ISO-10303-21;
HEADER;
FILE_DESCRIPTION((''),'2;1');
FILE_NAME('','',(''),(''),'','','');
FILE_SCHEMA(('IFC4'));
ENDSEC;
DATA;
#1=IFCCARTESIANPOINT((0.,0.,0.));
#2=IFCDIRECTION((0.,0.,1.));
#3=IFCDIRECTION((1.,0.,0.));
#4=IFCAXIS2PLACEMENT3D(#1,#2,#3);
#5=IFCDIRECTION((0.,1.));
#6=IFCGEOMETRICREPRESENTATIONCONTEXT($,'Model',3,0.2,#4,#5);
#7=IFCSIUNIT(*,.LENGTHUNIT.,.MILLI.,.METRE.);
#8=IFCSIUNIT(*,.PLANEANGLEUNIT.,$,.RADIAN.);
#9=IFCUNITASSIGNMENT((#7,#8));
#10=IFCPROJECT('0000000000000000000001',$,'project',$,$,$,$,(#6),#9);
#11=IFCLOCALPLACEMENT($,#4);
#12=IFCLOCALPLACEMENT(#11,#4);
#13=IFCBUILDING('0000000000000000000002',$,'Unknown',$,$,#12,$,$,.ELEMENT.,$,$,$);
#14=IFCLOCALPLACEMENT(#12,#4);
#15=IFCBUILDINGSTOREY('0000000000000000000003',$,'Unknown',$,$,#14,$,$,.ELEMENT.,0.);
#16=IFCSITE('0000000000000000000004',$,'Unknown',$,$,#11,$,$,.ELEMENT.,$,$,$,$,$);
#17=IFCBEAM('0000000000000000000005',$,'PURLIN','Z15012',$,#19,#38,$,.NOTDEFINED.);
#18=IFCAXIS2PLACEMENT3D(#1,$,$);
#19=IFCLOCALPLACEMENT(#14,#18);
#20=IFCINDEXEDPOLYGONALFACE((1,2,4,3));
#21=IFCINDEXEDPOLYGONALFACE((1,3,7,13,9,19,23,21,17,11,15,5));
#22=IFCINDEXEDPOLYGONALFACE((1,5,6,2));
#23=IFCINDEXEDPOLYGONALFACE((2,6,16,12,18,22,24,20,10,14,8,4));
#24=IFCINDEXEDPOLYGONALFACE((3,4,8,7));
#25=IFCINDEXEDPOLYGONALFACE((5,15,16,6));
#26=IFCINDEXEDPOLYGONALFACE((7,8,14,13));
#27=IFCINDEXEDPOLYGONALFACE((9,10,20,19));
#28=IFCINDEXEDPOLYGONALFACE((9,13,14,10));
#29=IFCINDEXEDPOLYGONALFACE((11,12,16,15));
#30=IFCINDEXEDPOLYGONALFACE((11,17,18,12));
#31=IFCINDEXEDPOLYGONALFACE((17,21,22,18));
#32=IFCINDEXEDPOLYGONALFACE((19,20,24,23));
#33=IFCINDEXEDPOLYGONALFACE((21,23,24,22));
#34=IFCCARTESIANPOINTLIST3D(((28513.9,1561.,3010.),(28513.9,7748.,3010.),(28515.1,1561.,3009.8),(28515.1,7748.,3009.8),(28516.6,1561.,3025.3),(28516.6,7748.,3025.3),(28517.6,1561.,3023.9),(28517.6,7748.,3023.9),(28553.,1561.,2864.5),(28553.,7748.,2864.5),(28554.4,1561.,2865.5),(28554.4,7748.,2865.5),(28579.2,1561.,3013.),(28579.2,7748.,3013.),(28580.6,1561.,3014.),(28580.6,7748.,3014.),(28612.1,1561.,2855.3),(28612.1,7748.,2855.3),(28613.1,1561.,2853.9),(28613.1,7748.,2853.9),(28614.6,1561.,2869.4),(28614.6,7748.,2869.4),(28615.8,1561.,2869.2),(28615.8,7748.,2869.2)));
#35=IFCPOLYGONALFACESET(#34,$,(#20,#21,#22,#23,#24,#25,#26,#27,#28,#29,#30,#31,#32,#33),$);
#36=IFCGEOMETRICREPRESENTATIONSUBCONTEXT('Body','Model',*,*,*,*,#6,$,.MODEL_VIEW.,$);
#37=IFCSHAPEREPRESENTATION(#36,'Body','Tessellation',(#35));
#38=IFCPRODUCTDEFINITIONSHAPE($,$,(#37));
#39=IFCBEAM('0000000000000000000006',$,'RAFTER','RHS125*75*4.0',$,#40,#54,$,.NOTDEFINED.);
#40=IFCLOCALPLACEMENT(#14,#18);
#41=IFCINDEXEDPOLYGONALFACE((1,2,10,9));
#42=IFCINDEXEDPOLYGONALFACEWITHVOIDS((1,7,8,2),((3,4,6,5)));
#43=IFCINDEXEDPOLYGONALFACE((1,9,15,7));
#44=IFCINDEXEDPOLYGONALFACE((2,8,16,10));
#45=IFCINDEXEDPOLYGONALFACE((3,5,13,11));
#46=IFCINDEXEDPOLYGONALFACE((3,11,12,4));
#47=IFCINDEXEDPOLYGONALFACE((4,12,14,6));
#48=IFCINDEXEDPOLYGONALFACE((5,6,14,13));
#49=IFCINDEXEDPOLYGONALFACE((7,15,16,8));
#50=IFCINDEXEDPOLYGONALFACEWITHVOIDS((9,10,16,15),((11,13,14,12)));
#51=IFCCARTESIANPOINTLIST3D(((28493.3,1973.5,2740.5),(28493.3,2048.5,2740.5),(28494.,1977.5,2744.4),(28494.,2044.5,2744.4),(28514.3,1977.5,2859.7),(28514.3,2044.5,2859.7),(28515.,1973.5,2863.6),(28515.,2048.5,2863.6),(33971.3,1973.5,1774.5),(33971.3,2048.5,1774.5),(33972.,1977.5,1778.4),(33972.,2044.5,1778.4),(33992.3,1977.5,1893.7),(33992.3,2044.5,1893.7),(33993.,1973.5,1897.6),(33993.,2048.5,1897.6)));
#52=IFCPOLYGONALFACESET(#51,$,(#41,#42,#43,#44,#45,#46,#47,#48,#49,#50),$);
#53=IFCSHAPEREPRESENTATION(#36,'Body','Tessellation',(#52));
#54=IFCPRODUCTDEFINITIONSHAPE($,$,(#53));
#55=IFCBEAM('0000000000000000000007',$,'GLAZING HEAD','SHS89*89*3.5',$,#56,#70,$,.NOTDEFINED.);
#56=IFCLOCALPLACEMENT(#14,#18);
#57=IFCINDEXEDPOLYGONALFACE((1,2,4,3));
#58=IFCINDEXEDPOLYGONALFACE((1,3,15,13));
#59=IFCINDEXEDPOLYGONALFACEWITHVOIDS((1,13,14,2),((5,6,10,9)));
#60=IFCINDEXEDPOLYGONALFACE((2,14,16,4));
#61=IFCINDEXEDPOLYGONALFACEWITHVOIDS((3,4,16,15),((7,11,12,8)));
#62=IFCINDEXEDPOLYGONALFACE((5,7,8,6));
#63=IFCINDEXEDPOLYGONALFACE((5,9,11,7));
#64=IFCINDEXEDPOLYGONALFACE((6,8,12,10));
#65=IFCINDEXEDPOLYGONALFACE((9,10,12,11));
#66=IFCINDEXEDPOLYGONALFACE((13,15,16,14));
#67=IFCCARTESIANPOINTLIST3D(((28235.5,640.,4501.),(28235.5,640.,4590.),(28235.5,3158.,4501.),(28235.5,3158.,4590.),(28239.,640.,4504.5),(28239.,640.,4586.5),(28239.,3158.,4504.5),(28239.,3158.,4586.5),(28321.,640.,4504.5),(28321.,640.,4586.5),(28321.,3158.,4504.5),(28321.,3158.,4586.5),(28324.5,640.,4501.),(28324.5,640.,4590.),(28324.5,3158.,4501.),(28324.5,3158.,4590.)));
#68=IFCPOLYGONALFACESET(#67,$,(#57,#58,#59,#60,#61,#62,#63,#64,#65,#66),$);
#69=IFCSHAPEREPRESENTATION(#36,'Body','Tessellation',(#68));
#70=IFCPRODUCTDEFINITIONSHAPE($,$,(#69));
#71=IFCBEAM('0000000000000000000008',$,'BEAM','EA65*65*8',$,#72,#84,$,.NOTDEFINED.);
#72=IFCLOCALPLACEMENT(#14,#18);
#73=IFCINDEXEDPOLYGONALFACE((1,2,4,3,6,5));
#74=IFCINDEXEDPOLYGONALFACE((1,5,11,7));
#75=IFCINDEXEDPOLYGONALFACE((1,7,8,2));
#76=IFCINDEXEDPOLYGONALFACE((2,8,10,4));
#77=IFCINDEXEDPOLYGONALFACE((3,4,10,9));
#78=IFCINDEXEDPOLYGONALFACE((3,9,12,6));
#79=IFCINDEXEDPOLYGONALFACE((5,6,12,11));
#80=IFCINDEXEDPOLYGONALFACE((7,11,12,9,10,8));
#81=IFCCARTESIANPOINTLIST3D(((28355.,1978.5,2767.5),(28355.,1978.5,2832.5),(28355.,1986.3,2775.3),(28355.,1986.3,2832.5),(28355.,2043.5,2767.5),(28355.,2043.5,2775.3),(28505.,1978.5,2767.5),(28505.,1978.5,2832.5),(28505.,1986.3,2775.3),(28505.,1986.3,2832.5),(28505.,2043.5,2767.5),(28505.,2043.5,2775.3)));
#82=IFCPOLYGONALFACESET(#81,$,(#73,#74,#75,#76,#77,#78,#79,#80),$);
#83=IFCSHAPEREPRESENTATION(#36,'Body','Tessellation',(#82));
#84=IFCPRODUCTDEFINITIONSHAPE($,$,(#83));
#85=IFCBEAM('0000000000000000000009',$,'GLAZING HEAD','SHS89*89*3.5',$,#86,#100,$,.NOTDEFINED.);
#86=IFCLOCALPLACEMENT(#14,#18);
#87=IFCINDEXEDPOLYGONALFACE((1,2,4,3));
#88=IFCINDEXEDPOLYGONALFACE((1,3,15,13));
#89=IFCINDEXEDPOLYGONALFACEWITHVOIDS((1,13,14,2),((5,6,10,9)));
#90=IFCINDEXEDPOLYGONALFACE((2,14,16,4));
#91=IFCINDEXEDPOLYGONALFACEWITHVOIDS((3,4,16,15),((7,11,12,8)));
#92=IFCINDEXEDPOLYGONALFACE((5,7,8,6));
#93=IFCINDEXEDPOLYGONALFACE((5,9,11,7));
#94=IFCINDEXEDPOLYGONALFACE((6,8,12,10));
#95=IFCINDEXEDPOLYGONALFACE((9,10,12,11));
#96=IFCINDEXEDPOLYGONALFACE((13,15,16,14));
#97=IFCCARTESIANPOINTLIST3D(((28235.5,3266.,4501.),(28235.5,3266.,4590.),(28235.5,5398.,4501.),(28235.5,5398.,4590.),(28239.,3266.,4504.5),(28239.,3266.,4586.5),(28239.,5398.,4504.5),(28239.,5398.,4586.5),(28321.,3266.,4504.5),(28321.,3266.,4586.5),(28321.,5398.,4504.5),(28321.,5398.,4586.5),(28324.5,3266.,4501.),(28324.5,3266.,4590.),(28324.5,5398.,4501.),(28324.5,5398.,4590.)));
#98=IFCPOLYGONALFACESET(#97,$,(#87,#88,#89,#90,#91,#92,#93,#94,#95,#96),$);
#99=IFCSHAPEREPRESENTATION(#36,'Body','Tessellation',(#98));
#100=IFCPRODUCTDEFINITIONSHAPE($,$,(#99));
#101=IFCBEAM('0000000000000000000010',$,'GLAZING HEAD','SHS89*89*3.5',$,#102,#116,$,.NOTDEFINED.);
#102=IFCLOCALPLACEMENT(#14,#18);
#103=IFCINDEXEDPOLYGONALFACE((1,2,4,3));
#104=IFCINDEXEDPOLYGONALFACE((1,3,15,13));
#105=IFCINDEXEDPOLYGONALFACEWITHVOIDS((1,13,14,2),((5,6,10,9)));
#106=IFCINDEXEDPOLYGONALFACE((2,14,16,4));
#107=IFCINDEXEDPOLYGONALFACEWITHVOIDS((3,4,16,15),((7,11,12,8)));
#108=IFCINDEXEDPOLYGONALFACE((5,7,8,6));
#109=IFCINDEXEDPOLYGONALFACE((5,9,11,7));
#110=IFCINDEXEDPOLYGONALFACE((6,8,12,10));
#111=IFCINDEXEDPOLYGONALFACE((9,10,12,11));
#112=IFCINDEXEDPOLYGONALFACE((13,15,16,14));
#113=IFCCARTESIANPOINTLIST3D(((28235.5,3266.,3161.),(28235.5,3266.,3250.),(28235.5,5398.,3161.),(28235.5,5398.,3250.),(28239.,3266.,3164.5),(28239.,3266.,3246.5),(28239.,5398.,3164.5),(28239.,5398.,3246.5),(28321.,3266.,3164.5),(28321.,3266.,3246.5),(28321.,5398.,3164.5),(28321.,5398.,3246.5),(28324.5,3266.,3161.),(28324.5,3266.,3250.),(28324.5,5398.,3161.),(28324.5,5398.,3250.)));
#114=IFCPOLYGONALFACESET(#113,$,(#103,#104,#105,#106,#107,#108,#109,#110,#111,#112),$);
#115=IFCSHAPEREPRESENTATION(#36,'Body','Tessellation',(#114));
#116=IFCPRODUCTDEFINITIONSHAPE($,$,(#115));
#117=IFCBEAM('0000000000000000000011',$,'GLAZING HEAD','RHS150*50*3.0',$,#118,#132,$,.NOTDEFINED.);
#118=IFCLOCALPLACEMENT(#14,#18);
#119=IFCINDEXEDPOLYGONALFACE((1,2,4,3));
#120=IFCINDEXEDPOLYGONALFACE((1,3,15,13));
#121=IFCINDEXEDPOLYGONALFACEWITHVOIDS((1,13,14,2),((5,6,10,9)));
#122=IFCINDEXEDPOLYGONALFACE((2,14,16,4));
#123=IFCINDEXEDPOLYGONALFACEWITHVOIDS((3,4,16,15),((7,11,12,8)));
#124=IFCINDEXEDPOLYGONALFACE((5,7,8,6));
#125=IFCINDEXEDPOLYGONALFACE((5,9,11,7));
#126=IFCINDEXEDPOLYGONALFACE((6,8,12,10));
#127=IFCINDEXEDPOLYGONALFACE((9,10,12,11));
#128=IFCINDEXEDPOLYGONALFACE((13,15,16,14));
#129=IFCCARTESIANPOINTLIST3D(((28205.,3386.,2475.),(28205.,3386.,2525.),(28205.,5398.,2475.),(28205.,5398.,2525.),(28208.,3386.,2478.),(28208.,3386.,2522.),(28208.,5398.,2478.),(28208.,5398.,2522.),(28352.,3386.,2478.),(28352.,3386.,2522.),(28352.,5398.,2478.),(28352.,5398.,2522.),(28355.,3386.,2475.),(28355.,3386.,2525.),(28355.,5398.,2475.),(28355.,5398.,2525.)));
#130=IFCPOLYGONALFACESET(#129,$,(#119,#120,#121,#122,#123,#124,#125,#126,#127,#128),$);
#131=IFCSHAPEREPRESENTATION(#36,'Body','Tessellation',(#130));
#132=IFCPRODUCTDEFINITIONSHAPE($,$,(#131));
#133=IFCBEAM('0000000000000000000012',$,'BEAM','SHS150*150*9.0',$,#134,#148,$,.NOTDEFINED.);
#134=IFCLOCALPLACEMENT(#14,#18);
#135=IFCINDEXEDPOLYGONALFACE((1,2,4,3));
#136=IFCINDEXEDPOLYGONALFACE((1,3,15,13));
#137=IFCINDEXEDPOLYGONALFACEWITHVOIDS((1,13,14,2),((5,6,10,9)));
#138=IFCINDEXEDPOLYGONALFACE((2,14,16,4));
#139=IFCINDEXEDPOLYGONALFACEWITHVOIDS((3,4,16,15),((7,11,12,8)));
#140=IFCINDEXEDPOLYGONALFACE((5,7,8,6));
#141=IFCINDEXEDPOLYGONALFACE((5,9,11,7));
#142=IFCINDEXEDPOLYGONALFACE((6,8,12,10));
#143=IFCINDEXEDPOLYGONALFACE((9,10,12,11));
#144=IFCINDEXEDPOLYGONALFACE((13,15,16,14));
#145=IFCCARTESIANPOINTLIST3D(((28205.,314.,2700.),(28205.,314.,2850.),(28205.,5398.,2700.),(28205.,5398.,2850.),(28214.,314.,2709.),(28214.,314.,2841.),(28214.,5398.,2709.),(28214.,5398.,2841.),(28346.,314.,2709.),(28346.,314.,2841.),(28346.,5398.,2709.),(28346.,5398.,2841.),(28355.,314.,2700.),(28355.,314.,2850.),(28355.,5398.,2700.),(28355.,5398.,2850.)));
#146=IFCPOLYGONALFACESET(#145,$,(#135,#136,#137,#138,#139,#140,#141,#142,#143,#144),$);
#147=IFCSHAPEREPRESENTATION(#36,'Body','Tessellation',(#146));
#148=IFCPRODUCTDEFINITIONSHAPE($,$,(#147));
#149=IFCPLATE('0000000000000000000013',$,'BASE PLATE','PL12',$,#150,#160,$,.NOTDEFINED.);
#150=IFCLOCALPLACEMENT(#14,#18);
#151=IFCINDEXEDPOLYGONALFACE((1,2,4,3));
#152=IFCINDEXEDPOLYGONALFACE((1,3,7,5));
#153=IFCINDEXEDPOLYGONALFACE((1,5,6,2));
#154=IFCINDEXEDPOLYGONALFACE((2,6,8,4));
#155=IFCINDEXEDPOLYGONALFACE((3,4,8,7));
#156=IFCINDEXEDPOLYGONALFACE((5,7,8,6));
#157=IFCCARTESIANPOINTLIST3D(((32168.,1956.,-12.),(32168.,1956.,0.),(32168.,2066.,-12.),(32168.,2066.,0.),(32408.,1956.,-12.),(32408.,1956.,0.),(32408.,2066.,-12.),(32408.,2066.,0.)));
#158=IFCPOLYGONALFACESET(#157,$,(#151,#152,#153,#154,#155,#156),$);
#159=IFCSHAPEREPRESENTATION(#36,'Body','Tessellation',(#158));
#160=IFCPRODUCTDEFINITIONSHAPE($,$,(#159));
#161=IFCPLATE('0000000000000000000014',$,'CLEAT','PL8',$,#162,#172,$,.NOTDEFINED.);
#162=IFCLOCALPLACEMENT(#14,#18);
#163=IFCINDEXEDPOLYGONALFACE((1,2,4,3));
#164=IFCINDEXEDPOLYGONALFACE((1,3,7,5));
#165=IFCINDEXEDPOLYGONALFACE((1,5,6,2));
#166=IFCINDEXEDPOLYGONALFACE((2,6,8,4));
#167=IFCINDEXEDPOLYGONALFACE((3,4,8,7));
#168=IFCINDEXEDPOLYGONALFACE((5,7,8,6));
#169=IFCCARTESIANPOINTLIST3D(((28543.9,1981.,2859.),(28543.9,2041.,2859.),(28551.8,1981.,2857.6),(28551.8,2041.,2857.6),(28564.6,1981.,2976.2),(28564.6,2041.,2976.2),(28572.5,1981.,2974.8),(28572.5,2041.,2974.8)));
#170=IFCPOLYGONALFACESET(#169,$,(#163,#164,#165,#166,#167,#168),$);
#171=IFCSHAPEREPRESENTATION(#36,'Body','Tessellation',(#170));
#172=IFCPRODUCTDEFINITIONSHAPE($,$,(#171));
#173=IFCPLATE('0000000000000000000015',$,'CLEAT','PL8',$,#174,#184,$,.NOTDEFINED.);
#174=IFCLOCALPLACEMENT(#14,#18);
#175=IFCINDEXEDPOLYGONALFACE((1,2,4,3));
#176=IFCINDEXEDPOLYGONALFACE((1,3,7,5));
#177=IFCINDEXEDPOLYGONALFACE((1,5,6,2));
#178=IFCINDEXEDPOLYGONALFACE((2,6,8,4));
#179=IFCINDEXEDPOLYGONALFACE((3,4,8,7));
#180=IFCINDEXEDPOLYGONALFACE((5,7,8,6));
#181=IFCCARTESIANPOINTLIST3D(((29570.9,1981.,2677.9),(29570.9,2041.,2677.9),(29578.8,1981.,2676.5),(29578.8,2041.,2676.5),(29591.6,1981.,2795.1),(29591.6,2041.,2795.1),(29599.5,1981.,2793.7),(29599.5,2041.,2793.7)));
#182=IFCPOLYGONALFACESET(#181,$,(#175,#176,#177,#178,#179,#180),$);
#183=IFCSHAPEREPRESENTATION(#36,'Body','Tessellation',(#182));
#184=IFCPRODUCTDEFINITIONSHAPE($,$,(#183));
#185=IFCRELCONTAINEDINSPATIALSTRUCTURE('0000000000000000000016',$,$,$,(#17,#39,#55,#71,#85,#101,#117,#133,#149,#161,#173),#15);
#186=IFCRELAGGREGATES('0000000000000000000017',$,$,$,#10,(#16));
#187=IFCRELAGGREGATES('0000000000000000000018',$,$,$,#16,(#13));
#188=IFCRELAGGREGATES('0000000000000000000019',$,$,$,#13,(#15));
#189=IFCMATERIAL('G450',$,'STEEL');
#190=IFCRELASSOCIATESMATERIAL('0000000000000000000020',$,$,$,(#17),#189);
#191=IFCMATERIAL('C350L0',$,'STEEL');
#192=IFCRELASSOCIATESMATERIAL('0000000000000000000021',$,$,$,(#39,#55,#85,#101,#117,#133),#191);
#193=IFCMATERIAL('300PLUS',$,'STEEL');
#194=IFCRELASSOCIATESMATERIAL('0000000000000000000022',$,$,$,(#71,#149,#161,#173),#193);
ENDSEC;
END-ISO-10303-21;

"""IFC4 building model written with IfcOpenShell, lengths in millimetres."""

from ifc_helpers import new_model, si_unit, direction, frame, origin_with_axes, place, context, subcontext, project, spatial, line, indexed_curve, outline, extrude, material, element, save


model = new_model("IFC4")

# Units and contexts
model_context = context("Model", 3, precision=0.2, world=origin_with_axes(), true_north=direction((0.0, 1.0)))
body_context = subcontext(model_context, "Body", "Model", "MODEL_VIEW")
ifc_project = project(units=[si_unit("LENGTHUNIT", "METRE", prefix="MILLI"), si_unit("PLANEANGLEUNIT", "RADIAN")], contexts=[model_context])

# Site, building, storey
site_placement = place(None, origin_with_axes())
site = spatial("IfcSite", under=ifc_project, at=site_placement, Name="Unknown", CompositionType="ELEMENT")
building_placement = place(site_placement, origin_with_axes())
building = spatial("IfcBuilding", under=site, at=building_placement, Name="Unknown", CompositionType="ELEMENT")
storey_placement = place(building_placement, origin_with_axes())
storey = spatial("IfcBuildingStorey", under=building, at=storey_placement, Name="Unknown", CompositionType="ELEMENT", Elevation=0.0)

# Shared definitions
ifc_material_1 = material(Name="C350L0", Category="STEEL")

# Beams
ifc_material_2 = material(Name="G450", Category="STEEL")
for number, where, z_axis, x_axis, name in (
    (1, (28566.8, 1561.0, 2939.3), (0.984808, 0.0, -0.173648), (0.0, 1.0, 0.0), "PURLIN"),
):
    element("IfcBeam", number, at=place(storey_placement, frame(where, z_axis=z_axis, x_axis=x_axis)), inside=storey, material=ifc_material_2, Name=name, Description="Z15012", PredefinedType="NOTDEFINED", context=body_context, shape_type="SolidModel", body=[
        extrude(outline(indexed_curve([(60.4, -76.0), (60.4, -60.5), (59.2, -60.5), (59.2, -74.8), (0.6, -74.8), (0.6, 76.0), (-64.4, 76.0), (-64.4, 60.5), (-63.2, 60.5), (-63.2, 74.8), (-0.6, 74.8), (-0.6, -76.0)], segments=[line(1, 2, 3, 4, 5, 6, 7, 8, 9, 10, 11, 12, 1)])), frame((0.0, 0.0, 0.0), z_axis=(-1.0, 0.0, 0.0), x_axis=(0.0, 0.0, 1.0)), (0.0, 0.0, -1.0), 6187.0),
    ])
beam_1_placement = place(storey_placement, frame((28504.1, 2011.0, 2802.0), z_axis=(0.0, -1.0, 0.0), x_axis=(0.984805, 0.0, -0.173662)))
element("IfcBeam", 2, at=beam_1_placement, inside=storey, material=ifc_material_1, Name="RAFTER", Description="RHS125*75*4.0", PredefinedType="NOTDEFINED", context=body_context, shape_type="SolidModel", body=[
    extrude(outline(indexed_curve([(-37.5, -62.5), (37.5, -62.5), (37.5, 62.5), (-37.5, 62.5)], segments=[line(1, 2, 3, 4, 1)]), holes=[indexed_curve([(-33.5, -58.5), (-33.5, 58.5), (33.5, 58.5), (33.5, -58.5)], segments=[line(1, 2, 3, 4, 1)])]), frame((0.0, 0.0, 0.0), z_axis=(-1.0, 0.0, 0.0), x_axis=(0.0, 0.0, 1.0)), (0.0, 0.0, -1.0), 5562.5),
])
beam_2_placement = place(storey_placement, frame((28280.0, 640.0, 4545.5), z_axis=(0.0, 0.0, 1.0), x_axis=(0.0, 1.0, 0.0)))
element("IfcBeam", 3, at=beam_2_placement, inside=storey, material=ifc_material_1, Name="GLAZING HEAD", Description="SHS89*89*3.5", PredefinedType="NOTDEFINED", context=body_context, shape_type="SolidModel", body=[
    extrude(outline(indexed_curve([(-44.5, -44.5), (44.5, -44.5), (44.5, 44.5), (-44.5, 44.5)], segments=[line(1, 2, 3, 4, 1)]), holes=[indexed_curve([(-41.0, -41.0), (-41.0, 41.0), (41.0, 41.0), (41.0, -41.0)], segments=[line(1, 2, 3, 4, 1)])]), frame((0.0, 0.0, 0.0), z_axis=(-1.0, 0.0, 0.0), x_axis=(0.0, 0.0, 1.0)), (0.0, 0.0, -1.0), 2518.0),
])
ifc_material_3 = material(Name="300PLUS", Category="STEEL")
beam_3_placement = place(storey_placement, frame((28355.0, 2011.0, 2800.0), z_axis=(0.0, 0.0, 1.0), x_axis=(1.0, 0.0, 0.0)))
element("IfcBeam", 4, at=beam_3_placement, inside=storey, material=ifc_material_3, Name="BEAM", Description="EA65*65*8", PredefinedType="NOTDEFINED", context=body_context, shape_type="SolidModel", body=[
    extrude(outline(indexed_curve([(-32.5, -32.5), (32.5, -32.5), (32.5, -24.7), (-24.7, -24.7), (-24.7, 32.5), (-32.5, 32.5)], segments=[line(1, 2, 3, 4, 5, 6, 1)])), frame((0.0, 0.0, 0.0), z_axis=(-1.0, 0.0, 0.0), x_axis=(0.0, 0.0, 1.0)), (0.0, 0.0, -1.0), 150.0),
])
for number, where, z_axis, x_axis, name in (
    (5, (28280.0, 3266.0, 4545.5), (0.0, 0.0, 1.0), (0.0, 1.0, 0.0), "GLAZING HEAD"),
    (6, (28280.0, 3266.0, 3205.5), (0.0, 0.0, 1.0), (0.0, 1.0, 0.0), "GLAZING HEAD"),
):
    element("IfcBeam", number, at=place(storey_placement, frame(where, z_axis=z_axis, x_axis=x_axis)), inside=storey, material=ifc_material_1, Name=name, Description="SHS89*89*3.5", PredefinedType="NOTDEFINED", context=body_context, shape_type="SolidModel", body=[
        extrude(outline(indexed_curve([(-44.5, -44.5), (44.5, -44.5), (44.5, 44.5), (-44.5, 44.5)], segments=[line(1, 2, 3, 4, 1)]), holes=[indexed_curve([(-41.0, -41.0), (-41.0, 41.0), (41.0, 41.0), (41.0, -41.0)], segments=[line(1, 2, 3, 4, 1)])]), frame((0.0, 0.0, 0.0), z_axis=(-1.0, 0.0, 0.0), x_axis=(0.0, 0.0, 1.0)), (0.0, 0.0, -1.0), 2132.0),
    ])
beam_4_placement = place(storey_placement, frame((28280.0, 3386.0, 2500.0), z_axis=(0.0, 0.0, 1.0), x_axis=(0.0, 1.0, 0.0)))
element("IfcBeam", 7, at=beam_4_placement, inside=storey, material=ifc_material_1, Name="GLAZING HEAD", Description="RHS150*50*3.0", PredefinedType="NOTDEFINED", context=body_context, shape_type="SolidModel", body=[
    extrude(outline(indexed_curve([(-25.0, -75.0), (25.0, -75.0), (25.0, 75.0), (-25.0, 75.0)], segments=[line(1, 2, 3, 4, 1)]), holes=[indexed_curve([(-22.0, -72.0), (-22.0, 72.0), (22.0, 72.0), (22.0, -72.0)], segments=[line(1, 2, 3, 4, 1)])]), frame((0.0, 0.0, 0.0), z_axis=(-1.0, 0.0, 0.0), x_axis=(0.0, 0.0, 1.0)), (0.0, 0.0, -1.0), 2012.0),
])
beam_5_placement = place(storey_placement, frame((28280.0, 314.0, 2775.0), z_axis=(0.0, 0.0, 1.0), x_axis=(0.0, 1.0, 0.0)))
element("IfcBeam", 8, at=beam_5_placement, inside=storey, material=ifc_material_1, Name="BEAM", Description="SHS150*150*9.0", PredefinedType="NOTDEFINED", context=body_context, shape_type="SolidModel", body=[
    extrude(outline(indexed_curve([(-75.0, -75.0), (75.0, -75.0), (75.0, 75.0), (-75.0, 75.0)], segments=[line(1, 2, 3, 4, 1)]), holes=[indexed_curve([(-66.0, -66.0), (-66.0, 66.0), (66.0, 66.0), (66.0, -66.0)], segments=[line(1, 2, 3, 4, 1)])]), frame((0.0, 0.0, 0.0), z_axis=(-1.0, 0.0, 0.0), x_axis=(0.0, 0.0, 1.0)), (0.0, 0.0, -1.0), 5084.0),
])

# Plates
plate_1_placement = place(storey_placement, frame((32168.0, 1956.0, -6.0), z_axis=(0.0, 0.0, 1.0), x_axis=(1.0, 0.0, 0.0)))
element("IfcPlate", 9, at=plate_1_placement, inside=storey, material=ifc_material_3, Name="BASE PLATE", Description="PL12", PredefinedType="NOTDEFINED", context=body_context, shape_type="SolidModel", body=[
    extrude(outline(indexed_curve([(0.0, 0.0), (240.0, 0.0), (240.0, 110.0), (0.0, 110.0)], segments=[line(1, 2, 3, 4, 1)])), frame((0.0, 0.0, 6.0), z_axis=(0.0, 0.0, 1.0), x_axis=(1.0, 0.0, 0.0)), (0.0, 0.0, -1.0), 12.0),
])
for number, where, z_axis, x_axis, name in (
    (10, (28547.9, 2041.0, 2858.3), (-0.984758, 0.0, 0.173929), (0.0, -1.0, 0.0), "CLEAT"),
    (11, (29574.9, 2041.0, 2677.2), (-0.984758, 0.0, 0.173929), (0.0, -1.0, 0.0), "CLEAT"),
):
    element("IfcPlate", number, at=place(storey_placement, frame(where, z_axis=z_axis, x_axis=x_axis)), inside=storey, material=ifc_material_3, Name=name, Description="PL8", PredefinedType="NOTDEFINED", context=body_context, shape_type="SolidModel", body=[
        extrude(outline(indexed_curve([(0.0, 0.0), (60.0, 0.0), (60.0, 119.0), (0.0, 119.0)], segments=[line(1, 2, 3, 4, 1)])), frame((0.0, 0.0, 4.0), z_axis=(0.0, 0.0, 1.0), x_axis=(1.0, 0.0, 0.0)), (0.0, 0.0, -1.0), 8.0),
    ])

save(model, "model.ifc")
